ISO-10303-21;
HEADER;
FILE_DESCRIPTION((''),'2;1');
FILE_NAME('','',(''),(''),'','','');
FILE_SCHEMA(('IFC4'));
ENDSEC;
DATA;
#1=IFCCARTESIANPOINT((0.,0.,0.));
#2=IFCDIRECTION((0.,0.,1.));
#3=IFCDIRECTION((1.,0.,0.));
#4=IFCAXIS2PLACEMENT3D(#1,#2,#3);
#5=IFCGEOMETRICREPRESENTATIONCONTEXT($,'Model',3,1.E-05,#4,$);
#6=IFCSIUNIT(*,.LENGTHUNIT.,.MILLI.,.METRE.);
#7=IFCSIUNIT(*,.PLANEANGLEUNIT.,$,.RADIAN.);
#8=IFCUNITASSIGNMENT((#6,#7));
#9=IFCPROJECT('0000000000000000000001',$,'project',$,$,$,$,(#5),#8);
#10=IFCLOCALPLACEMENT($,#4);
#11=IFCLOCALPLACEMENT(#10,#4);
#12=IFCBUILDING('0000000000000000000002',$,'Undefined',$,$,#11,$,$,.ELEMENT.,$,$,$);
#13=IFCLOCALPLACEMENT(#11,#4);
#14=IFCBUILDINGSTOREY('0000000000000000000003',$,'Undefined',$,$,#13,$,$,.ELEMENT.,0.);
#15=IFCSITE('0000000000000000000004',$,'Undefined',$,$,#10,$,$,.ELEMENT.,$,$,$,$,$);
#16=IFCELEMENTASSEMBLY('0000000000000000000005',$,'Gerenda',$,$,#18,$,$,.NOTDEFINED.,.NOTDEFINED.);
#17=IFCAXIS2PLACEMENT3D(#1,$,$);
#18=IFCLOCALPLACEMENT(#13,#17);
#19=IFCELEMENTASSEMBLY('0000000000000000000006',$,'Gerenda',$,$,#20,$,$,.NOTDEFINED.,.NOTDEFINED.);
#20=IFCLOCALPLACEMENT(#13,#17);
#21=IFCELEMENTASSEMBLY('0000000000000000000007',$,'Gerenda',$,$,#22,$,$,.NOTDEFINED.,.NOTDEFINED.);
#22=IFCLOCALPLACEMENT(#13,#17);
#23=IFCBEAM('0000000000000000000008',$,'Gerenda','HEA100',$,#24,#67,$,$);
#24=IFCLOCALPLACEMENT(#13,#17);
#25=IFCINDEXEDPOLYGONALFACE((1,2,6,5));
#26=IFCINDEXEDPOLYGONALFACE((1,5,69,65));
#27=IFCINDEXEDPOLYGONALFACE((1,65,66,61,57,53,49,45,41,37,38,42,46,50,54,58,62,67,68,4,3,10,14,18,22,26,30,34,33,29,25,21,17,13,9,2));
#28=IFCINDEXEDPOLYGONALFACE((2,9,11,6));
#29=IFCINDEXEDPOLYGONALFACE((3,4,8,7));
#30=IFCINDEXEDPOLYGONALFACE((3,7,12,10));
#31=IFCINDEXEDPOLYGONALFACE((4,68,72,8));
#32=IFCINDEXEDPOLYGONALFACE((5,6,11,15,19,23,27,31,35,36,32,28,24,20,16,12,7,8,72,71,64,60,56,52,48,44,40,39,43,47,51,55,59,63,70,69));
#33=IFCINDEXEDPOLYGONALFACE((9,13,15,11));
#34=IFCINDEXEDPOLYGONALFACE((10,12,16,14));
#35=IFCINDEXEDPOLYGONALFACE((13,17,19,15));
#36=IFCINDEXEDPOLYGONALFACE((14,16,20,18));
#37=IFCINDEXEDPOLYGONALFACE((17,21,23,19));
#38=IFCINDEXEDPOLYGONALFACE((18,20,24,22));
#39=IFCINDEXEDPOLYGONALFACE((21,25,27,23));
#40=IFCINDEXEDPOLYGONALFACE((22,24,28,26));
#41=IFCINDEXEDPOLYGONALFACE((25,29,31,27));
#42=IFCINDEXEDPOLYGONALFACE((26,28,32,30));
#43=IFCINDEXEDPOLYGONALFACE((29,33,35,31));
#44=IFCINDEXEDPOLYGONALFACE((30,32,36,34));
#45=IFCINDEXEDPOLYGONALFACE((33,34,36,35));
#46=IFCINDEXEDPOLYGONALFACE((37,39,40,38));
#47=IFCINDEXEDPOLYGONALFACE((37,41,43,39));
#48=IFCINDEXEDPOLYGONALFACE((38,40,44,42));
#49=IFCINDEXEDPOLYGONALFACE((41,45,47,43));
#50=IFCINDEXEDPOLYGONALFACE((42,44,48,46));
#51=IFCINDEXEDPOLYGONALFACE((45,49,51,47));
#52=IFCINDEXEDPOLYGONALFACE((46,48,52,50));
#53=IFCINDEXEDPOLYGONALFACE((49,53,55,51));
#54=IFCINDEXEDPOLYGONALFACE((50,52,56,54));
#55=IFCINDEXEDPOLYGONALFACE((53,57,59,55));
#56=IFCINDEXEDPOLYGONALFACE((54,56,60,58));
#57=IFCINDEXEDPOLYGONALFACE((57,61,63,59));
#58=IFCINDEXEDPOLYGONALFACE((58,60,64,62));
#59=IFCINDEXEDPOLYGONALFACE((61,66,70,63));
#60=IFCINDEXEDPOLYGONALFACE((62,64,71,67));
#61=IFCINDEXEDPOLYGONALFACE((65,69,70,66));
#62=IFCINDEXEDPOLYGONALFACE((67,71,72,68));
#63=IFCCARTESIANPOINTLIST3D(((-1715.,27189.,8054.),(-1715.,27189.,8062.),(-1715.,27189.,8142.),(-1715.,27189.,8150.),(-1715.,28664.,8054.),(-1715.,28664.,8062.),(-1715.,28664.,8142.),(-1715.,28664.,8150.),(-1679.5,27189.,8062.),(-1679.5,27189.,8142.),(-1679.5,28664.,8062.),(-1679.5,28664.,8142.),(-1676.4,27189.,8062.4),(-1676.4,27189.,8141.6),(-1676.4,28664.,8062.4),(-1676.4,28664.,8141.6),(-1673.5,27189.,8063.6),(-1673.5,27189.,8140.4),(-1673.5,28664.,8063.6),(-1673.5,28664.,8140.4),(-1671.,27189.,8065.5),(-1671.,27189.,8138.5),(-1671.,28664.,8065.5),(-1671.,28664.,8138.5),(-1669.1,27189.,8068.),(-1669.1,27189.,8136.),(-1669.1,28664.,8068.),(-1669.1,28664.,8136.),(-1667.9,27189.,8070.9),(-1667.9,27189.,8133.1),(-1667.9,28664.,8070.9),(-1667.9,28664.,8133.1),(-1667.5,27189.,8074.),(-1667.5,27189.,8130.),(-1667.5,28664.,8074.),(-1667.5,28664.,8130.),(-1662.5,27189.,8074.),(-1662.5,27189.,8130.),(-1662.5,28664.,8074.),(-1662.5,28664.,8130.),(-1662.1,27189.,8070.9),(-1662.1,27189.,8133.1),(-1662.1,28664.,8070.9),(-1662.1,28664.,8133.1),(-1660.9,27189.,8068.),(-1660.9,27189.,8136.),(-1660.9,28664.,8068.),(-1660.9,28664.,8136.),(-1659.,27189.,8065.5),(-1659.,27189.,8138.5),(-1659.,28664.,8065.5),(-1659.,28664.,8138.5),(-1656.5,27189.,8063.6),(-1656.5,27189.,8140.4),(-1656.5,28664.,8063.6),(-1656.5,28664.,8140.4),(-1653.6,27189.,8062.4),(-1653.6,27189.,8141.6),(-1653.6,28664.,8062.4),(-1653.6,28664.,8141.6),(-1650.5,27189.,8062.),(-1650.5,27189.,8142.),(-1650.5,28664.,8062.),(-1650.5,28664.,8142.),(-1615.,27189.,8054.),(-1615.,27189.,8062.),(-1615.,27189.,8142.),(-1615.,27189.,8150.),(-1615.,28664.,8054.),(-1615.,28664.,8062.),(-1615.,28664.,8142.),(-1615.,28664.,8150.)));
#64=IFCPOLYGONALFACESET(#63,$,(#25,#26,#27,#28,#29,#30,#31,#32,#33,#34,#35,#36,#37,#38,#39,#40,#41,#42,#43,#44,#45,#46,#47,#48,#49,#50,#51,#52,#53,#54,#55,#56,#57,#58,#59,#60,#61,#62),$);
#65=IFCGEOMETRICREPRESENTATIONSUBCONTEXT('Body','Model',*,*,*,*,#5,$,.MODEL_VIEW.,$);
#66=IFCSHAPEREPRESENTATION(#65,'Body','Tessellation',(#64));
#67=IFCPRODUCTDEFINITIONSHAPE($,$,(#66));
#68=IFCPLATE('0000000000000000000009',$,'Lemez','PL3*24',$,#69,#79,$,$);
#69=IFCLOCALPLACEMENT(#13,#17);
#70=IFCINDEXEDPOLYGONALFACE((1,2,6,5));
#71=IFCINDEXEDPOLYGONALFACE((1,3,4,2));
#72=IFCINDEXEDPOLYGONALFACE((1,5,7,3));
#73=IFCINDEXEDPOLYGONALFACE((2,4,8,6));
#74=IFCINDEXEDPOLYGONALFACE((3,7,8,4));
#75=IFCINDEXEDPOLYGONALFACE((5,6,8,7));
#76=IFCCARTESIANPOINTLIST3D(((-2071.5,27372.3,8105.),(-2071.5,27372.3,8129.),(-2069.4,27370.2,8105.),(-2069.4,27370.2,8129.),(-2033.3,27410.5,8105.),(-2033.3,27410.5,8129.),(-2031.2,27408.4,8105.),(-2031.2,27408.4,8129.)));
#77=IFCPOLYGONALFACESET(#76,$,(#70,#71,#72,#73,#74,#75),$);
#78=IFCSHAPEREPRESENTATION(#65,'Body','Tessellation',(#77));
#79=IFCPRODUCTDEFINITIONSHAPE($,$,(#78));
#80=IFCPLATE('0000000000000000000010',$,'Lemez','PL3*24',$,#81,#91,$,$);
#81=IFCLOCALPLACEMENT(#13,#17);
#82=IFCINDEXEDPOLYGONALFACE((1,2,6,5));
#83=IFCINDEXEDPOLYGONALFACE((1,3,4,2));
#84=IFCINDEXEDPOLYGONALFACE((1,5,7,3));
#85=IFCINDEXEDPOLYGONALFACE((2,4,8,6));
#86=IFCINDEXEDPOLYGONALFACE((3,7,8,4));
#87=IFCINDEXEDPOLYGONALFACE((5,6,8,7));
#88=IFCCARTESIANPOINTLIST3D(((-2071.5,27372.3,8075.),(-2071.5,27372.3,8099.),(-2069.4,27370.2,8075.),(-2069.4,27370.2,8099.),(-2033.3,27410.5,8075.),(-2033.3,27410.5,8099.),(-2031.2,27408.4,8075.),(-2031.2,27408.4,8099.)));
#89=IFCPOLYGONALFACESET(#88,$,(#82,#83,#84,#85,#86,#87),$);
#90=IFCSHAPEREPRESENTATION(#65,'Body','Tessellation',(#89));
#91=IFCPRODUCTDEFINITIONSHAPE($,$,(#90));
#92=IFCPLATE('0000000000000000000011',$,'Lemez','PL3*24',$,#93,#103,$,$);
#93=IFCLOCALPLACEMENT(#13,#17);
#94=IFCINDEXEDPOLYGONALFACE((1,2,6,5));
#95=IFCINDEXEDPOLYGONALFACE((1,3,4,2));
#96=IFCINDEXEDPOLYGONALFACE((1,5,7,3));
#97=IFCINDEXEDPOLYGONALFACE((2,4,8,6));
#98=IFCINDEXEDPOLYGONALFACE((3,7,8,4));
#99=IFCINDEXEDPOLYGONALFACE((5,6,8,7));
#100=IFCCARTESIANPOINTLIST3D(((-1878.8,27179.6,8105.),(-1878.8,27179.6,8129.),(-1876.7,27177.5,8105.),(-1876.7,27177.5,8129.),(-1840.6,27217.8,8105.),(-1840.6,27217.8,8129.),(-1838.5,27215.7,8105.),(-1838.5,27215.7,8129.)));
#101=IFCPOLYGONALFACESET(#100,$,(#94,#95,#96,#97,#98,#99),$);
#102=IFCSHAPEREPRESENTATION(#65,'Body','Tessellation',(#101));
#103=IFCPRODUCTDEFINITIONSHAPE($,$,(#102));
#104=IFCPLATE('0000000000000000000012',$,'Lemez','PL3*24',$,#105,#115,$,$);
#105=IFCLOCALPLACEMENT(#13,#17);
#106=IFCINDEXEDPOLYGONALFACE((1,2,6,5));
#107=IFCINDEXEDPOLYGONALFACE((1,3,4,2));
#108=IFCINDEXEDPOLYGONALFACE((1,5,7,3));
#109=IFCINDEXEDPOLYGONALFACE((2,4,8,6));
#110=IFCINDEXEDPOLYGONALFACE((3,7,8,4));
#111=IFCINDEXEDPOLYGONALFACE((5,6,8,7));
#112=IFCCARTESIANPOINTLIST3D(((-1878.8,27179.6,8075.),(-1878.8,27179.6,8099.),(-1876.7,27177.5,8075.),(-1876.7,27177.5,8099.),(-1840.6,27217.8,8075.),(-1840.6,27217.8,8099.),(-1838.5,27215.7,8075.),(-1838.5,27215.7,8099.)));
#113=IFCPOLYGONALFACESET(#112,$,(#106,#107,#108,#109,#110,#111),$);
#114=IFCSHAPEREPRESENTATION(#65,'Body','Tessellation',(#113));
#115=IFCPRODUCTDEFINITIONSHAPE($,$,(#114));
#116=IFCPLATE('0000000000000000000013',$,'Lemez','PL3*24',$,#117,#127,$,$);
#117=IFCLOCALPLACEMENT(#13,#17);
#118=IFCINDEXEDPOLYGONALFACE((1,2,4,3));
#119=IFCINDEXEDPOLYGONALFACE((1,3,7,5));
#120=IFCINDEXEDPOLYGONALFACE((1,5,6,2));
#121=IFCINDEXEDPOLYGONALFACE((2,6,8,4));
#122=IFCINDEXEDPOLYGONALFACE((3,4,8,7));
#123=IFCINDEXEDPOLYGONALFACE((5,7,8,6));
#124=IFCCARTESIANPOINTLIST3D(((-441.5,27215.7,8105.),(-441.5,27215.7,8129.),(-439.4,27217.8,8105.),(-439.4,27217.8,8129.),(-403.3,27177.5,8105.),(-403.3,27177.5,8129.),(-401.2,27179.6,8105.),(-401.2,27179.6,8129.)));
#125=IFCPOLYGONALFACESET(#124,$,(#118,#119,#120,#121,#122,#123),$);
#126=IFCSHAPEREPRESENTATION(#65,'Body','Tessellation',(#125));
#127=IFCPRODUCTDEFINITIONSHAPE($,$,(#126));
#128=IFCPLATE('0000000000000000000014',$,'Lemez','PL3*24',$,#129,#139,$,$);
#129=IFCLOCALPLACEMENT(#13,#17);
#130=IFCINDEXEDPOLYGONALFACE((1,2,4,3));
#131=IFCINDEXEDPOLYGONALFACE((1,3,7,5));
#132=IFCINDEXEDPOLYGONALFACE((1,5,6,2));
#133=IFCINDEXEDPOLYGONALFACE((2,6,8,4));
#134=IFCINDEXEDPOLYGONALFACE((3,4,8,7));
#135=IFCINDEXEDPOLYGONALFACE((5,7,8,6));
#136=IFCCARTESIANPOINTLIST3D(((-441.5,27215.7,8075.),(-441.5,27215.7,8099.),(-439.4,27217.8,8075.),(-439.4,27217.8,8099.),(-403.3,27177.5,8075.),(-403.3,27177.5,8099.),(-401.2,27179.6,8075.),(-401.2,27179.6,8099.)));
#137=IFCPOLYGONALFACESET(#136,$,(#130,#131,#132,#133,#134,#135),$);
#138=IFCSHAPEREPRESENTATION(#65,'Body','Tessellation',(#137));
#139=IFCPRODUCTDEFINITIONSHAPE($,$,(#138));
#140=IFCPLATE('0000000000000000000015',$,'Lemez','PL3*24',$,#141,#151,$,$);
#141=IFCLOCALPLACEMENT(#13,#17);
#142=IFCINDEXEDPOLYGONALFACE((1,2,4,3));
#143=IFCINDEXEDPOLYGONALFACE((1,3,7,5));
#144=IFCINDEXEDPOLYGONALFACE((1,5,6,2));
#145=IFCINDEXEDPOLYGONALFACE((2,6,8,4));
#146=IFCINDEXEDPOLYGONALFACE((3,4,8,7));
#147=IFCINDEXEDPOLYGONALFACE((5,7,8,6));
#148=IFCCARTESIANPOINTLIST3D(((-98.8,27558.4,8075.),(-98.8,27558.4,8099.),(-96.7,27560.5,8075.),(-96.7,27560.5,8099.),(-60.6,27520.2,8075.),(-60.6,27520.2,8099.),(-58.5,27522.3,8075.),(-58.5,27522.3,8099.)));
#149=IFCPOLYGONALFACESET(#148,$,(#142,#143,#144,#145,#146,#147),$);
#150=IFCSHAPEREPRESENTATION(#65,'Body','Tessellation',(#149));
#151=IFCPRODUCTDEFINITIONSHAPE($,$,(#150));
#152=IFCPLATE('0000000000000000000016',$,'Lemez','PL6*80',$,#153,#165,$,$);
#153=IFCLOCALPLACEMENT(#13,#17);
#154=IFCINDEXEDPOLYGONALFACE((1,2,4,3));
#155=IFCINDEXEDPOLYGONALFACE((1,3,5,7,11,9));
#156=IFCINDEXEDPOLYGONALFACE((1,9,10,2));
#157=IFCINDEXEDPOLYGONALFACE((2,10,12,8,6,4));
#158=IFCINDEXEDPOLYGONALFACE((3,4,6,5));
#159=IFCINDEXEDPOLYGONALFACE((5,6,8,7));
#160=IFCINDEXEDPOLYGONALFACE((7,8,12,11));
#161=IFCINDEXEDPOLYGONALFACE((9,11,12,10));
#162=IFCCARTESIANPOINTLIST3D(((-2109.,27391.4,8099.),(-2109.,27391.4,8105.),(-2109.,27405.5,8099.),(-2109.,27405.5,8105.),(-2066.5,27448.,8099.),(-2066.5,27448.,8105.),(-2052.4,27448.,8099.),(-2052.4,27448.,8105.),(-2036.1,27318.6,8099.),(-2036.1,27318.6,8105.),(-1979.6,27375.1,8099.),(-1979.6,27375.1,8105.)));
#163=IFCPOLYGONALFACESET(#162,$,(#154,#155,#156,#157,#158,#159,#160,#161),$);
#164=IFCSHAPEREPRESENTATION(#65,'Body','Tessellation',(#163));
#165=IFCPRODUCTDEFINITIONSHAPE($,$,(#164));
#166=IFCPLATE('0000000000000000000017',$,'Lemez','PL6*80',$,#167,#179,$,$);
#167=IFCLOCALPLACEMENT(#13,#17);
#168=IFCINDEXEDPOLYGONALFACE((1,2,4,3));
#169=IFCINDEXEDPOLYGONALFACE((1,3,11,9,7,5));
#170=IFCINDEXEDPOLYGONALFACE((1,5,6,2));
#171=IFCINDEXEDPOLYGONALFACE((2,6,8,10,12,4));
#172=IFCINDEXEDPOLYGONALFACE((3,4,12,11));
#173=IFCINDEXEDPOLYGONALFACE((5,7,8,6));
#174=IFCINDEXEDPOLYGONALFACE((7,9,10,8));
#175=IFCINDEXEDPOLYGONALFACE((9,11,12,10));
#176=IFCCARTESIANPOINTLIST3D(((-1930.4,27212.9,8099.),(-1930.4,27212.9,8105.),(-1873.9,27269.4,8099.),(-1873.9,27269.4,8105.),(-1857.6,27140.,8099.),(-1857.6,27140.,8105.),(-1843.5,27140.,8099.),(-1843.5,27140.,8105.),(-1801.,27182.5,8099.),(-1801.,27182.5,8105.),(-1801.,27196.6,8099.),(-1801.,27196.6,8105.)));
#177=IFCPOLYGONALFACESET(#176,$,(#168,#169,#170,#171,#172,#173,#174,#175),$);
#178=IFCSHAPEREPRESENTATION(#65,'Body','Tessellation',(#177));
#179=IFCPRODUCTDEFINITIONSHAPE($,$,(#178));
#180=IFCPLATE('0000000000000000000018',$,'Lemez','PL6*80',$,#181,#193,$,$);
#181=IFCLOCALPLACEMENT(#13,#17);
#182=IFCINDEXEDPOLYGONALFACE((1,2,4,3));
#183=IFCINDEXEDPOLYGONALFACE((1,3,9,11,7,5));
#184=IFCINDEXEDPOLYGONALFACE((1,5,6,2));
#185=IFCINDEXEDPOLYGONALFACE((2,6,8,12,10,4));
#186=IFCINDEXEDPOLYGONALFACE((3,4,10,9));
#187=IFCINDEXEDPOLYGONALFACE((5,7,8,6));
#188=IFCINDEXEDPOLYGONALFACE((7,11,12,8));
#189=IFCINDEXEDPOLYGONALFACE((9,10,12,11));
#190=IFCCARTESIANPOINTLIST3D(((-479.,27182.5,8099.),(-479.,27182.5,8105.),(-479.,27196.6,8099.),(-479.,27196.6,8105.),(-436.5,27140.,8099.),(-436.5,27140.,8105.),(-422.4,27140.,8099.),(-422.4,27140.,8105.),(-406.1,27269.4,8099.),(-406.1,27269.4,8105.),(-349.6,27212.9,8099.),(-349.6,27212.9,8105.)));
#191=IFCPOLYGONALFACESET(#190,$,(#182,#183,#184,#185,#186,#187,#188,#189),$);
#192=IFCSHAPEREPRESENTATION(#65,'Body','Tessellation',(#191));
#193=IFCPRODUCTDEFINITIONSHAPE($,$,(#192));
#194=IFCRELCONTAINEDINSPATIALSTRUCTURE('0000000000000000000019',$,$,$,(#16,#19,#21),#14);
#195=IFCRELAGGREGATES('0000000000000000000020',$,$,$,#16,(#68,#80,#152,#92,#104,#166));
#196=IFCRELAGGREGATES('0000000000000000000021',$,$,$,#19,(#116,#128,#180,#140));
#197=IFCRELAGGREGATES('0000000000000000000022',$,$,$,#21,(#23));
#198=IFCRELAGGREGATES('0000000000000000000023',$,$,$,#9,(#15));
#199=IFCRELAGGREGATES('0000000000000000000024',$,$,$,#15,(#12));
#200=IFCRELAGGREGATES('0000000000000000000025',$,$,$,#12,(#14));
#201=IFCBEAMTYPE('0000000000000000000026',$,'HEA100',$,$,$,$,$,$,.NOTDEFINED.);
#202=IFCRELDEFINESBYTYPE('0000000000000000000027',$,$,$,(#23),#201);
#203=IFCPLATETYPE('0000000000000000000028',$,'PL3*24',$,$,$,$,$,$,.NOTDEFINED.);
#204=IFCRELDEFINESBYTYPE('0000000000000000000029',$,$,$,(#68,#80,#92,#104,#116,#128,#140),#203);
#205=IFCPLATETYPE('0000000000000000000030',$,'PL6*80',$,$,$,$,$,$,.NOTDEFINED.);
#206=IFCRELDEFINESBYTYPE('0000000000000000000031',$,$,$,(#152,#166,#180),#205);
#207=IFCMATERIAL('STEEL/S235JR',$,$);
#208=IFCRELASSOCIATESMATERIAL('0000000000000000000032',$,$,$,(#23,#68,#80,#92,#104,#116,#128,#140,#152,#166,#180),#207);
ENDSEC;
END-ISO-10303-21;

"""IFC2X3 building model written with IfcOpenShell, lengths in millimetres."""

from ifc_helpers import new_model, si_unit, frame, origin_with_axes, origin_2d_with_axis, place, context, subcontext, project, spatial, polyline, i_section, outline, extrude, clip, halfspace, material, type_object, element, aggregate, save


model = new_model("IFC2X3")

# Units and contexts
model_context = context("Model", 3, precision=1e-05, world=origin_with_axes())
body_context = subcontext(model_context, "Body", "Model", "MODEL_VIEW")
ifc_project = project(units=[si_unit("LENGTHUNIT", "METRE", prefix="MILLI"), si_unit("PLANEANGLEUNIT", "RADIAN")], contexts=[model_context])

# Site, building, storey
site_placement = place(None, origin_with_axes())
site = spatial("IfcSite", under=ifc_project, at=site_placement, Name="Undefined", CompositionType="ELEMENT")
building_placement = place(site_placement, origin_with_axes())
building = spatial("IfcBuilding", under=site, at=building_placement, Name="Undefined", CompositionType="ELEMENT")
storey_placement = place(building_placement, origin_with_axes())
storey = spatial("IfcBuildingStorey", under=building, at=storey_placement, Name="Undefined", CompositionType="ELEMENT", Elevation=0.0)

# Element assemblies, beam
ifc_material_1 = material(Name="STEEL/S235JR")
assembly_1_placement = place(storey_placement, origin_with_axes())
assembly_1 = element("IfcElementAssembly", 1, at=assembly_1_placement, inside=storey, Name="Gerenda", AssemblyPlace="NOTDEFINED", PredefinedType="NOTDEFINED")
assembly_2_placement = place(storey_placement, origin_with_axes())
assembly_2 = element("IfcElementAssembly", 2, at=assembly_2_placement, inside=storey, Name="Gerenda", AssemblyPlace="NOTDEFINED", PredefinedType="NOTDEFINED")
assembly_3_placement = place(storey_placement, origin_with_axes())
assembly_3 = element("IfcElementAssembly", 3, at=assembly_3_placement, inside=storey, Name="Gerenda", AssemblyPlace="NOTDEFINED", PredefinedType="NOTDEFINED")
beam_type_1 = type_object("IfcBeamType", Name="HEA100", PredefinedType="NOTDEFINED")
beam_1_placement = place(assembly_3_placement, frame((-1665.0, 27119.0, 8102.0), z_axis=(0.0, 0.0, 1.0), x_axis=(0.000003, 1.0, 0.0)))
beam_1 = element("IfcBeam", 4, at=beam_1_placement, type_object=beam_type_1, material=ifc_material_1, Name="Gerenda", Description="HEA100", context=body_context, shape_type="Clipping", body=[
    clip(clip(extrude(i_section(OverallWidth=100.0, OverallDepth=96.0, WebThickness=5.0, FlangeThickness=8.0, FilletRadius=12.0, at=origin_2d_with_axis()), frame((1615.0, 0.0, 0.0), z_axis=(-1.0, 0.0, 0.0), x_axis=(0.0, -1.0, 0.0)), (0.0, 0.0, 1.0), 1615.0), halfspace(frame((1545.0, 0.0, -48.0), z_axis=(-1.0, 0.0, 0.0), x_axis=(0.0, 1.0, 0.0)), True)), halfspace(frame((70.0, 0.0, -48.0), z_axis=(1.0, 0.0, 0.0), x_axis=(0.0, -1.0, 0.0)), True)),
])

# Plates
plate_type_1 = type_object("IfcPlateType", Name="PL3*24", PredefinedType="NOTDEFINED")
plate_1_placement = place(assembly_1_placement, frame((-2070.4, 27371.2, 8129.0), z_axis=(0.707112, -0.707102, 0.0), x_axis=(0.0, 0.0, -1.0)))
plate_1 = element("IfcPlate", 5, at=plate_1_placement, type_object=plate_type_1, material=ifc_material_1, Name="Lemez", Description="PL3*24", context=body_context, shape_type="SweptSolid", body=[
    extrude(outline(polyline([(0.0, 0.0), (24.0, 0.0), (24.0, 54.0), (0.0, 54.0), (0.0, 0.0)])), frame((0.0, 0.0, -1.5), z_axis=(0.0, 0.0, 1.0), x_axis=(1.0, 0.0, 0.0)), (0.0, 0.0, 1.0), 3.0),
])
plate_2_placement = place(assembly_1_placement, frame((-2070.4, 27371.2, 8099.0), z_axis=(0.707112, -0.707102, 0.0), x_axis=(0.0, 0.0, -1.0)))
plate_2 = element("IfcPlate", 6, at=plate_2_placement, type_object=plate_type_1, material=ifc_material_1, Name="Lemez", Description="PL3*24", context=body_context, shape_type="SweptSolid", body=[
    extrude(outline(polyline([(0.0, 0.0), (24.0, 0.0), (24.0, 54.0), (0.0, 54.0), (0.0, 0.0)])), frame((0.0, 0.0, -1.5), z_axis=(0.0, 0.0, 1.0), x_axis=(1.0, 0.0, 0.0)), (0.0, 0.0, 1.0), 3.0),
])
plate_3_placement = place(assembly_1_placement, frame((-1839.6, 27216.8, 8129.0), z_axis=(-0.707112, 0.707102, 0.0), x_axis=(0.0, 0.0, -1.0)))
plate_3 = element("IfcPlate", 7, at=plate_3_placement, type_object=plate_type_1, material=ifc_material_1, Name="Lemez", Description="PL3*24", context=body_context, shape_type="SweptSolid", body=[
    extrude(outline(polyline([(0.0, 0.0), (24.0, 0.0), (24.0, 54.0), (0.0, 54.0), (0.0, 0.0)])), frame((0.0, 0.0, -1.5), z_axis=(0.0, 0.0, 1.0), x_axis=(1.0, 0.0, 0.0)), (0.0, 0.0, 1.0), 3.0),
])
plate_4_placement = place(assembly_1_placement, frame((-1839.6, 27216.8, 8099.0), z_axis=(-0.707112, 0.707102, 0.0), x_axis=(0.0, 0.0, -1.0)))
plate_4 = element("IfcPlate", 8, at=plate_4_placement, type_object=plate_type_1, material=ifc_material_1, Name="Lemez", Description="PL3*24", context=body_context, shape_type="SweptSolid", body=[
    extrude(outline(polyline([(0.0, 0.0), (24.0, 0.0), (24.0, 54.0), (0.0, 54.0), (0.0, 0.0)])), frame((0.0, 0.0, -1.5), z_axis=(0.0, 0.0, 1.0), x_axis=(1.0, 0.0, 0.0)), (0.0, 0.0, 1.0), 3.0),
])
plate_5_placement = place(assembly_2_placement, frame((-402.2, 27178.6, 8129.0), z_axis=(0.707112, 0.707102, 0.0), x_axis=(0.0, 0.0, -1.0)))
plate_5 = element("IfcPlate", 9, at=plate_5_placement, type_object=plate_type_1, material=ifc_material_1, Name="Lemez", Description="PL3*24", context=body_context, shape_type="SweptSolid", body=[
    extrude(outline(polyline([(0.0, 0.0), (24.0, 0.0), (24.0, 54.0), (0.0, 54.0), (0.0, 0.0)])), frame((0.0, 0.0, -1.5), z_axis=(0.0, 0.0, 1.0), x_axis=(1.0, 0.0, 0.0)), (0.0, 0.0, 1.0), 3.0),
])
plate_6_placement = place(assembly_2_placement, frame((-402.2, 27178.6, 8099.0), z_axis=(0.707112, 0.707102, 0.0), x_axis=(0.0, 0.0, -1.0)))
plate_6 = element("IfcPlate", 10, at=plate_6_placement, type_object=plate_type_1, material=ifc_material_1, Name="Lemez", Description="PL3*24", context=body_context, shape_type="SweptSolid", body=[
    extrude(outline(polyline([(0.0, 0.0), (24.0, 0.0), (24.0, 54.0), (0.0, 54.0), (0.0, 0.0)])), frame((0.0, 0.0, -1.5), z_axis=(0.0, 0.0, 1.0), x_axis=(1.0, 0.0, 0.0)), (0.0, 0.0, 1.0), 3.0),
])
plate_7_placement = place(assembly_2_placement, frame((-97.7, 27559.4, 8099.0), z_axis=(-0.707112, -0.707102, 0.0), x_axis=(0.0, 0.0, -1.0)))
plate_7 = element("IfcPlate", 11, at=plate_7_placement, type_object=plate_type_1, material=ifc_material_1, Name="Lemez", Description="PL3*24", context=body_context, shape_type="SweptSolid", body=[
    extrude(outline(polyline([(0.0, 0.0), (24.0, 0.0), (24.0, 54.0), (0.0, 54.0), (0.0, 0.0)])), frame((0.0, 0.0, -1.5), z_axis=(0.0, 0.0, 1.0), x_axis=(1.0, 0.0, 0.0)), (0.0, 0.0, 1.0), 3.0),
])
plate_type_2 = type_object("IfcPlateType", Name="PL6*80", PredefinedType="NOTDEFINED")
plate_8_placement = place(assembly_1_placement, frame((-2052.4, 27448.0, 8102.0), z_axis=(0.0, 0.0, 1.0), x_axis=(-1.0, -0.000007, 0.0)))
plate_8 = element("IfcPlate", 12, at=plate_8_placement, type_object=plate_type_2, material=ifc_material_1, Name="Lemez", Description="PL6*80", context=body_context, shape_type="SweptSolid", body=[
    extrude(outline(polyline([(0.0, 0.0), (14.1, 0.0), (56.6, 42.4), (56.6, 56.6), (-16.3, 129.4), (-72.8, 72.8), (0.0, 0.0)])), frame((0.0, 0.0, -3.0), z_axis=(0.0, 0.0, 1.0), x_axis=(1.0, 0.0, 0.0)), (0.0, 0.0, 1.0), 6.0),
])
plate_9_placement = place(assembly_1_placement, frame((-1857.6, 27140.0, 8102.0), z_axis=(0.0, 0.0, 1.0), x_axis=(1.0, 0.000007, 0.0)))
plate_9 = element("IfcPlate", 13, at=plate_9_placement, type_object=plate_type_2, material=ifc_material_1, Name="Lemez", Description="PL6*80", context=body_context, shape_type="SweptSolid", body=[
    extrude(outline(polyline([(0.0, 0.0), (14.1, 0.0), (56.6, 42.4), (56.6, 56.6), (-16.3, 129.4), (-72.8, 72.8), (0.0, 0.0)])), frame((0.0, 0.0, -3.0), z_axis=(0.0, 0.0, 1.0), x_axis=(1.0, 0.0, 0.0)), (0.0, 0.0, 1.0), 6.0),
])
plate_10_placement = place(assembly_2_placement, frame((-479.0, 27196.6, 8102.0), z_axis=(0.0, 0.0, 1.0), x_axis=(-0.000007, -1.0, 0.0)))
plate_10 = element("IfcPlate", 14, at=plate_10_placement, type_object=plate_type_2, material=ifc_material_1, Name="Lemez", Description="PL6*80", context=body_context, shape_type="SweptSolid", body=[
    extrude(outline(polyline([(0.0, 0.0), (14.1, 0.0), (56.6, 42.4), (56.6, 56.6), (-16.3, 129.4), (-72.8, 72.8), (0.0, 0.0)])), frame((0.0, 0.0, -3.0), z_axis=(0.0, 0.0, 1.0), x_axis=(1.0, 0.0, 0.0)), (0.0, 0.0, 1.0), 6.0),
])

aggregate(assembly_1, [plate_1, plate_2, plate_8, plate_3, plate_4, plate_9])
aggregate(assembly_2, [plate_5, plate_6, plate_10, plate_7])
aggregate(assembly_3, [beam_1])

save(model, "model.ifc")
